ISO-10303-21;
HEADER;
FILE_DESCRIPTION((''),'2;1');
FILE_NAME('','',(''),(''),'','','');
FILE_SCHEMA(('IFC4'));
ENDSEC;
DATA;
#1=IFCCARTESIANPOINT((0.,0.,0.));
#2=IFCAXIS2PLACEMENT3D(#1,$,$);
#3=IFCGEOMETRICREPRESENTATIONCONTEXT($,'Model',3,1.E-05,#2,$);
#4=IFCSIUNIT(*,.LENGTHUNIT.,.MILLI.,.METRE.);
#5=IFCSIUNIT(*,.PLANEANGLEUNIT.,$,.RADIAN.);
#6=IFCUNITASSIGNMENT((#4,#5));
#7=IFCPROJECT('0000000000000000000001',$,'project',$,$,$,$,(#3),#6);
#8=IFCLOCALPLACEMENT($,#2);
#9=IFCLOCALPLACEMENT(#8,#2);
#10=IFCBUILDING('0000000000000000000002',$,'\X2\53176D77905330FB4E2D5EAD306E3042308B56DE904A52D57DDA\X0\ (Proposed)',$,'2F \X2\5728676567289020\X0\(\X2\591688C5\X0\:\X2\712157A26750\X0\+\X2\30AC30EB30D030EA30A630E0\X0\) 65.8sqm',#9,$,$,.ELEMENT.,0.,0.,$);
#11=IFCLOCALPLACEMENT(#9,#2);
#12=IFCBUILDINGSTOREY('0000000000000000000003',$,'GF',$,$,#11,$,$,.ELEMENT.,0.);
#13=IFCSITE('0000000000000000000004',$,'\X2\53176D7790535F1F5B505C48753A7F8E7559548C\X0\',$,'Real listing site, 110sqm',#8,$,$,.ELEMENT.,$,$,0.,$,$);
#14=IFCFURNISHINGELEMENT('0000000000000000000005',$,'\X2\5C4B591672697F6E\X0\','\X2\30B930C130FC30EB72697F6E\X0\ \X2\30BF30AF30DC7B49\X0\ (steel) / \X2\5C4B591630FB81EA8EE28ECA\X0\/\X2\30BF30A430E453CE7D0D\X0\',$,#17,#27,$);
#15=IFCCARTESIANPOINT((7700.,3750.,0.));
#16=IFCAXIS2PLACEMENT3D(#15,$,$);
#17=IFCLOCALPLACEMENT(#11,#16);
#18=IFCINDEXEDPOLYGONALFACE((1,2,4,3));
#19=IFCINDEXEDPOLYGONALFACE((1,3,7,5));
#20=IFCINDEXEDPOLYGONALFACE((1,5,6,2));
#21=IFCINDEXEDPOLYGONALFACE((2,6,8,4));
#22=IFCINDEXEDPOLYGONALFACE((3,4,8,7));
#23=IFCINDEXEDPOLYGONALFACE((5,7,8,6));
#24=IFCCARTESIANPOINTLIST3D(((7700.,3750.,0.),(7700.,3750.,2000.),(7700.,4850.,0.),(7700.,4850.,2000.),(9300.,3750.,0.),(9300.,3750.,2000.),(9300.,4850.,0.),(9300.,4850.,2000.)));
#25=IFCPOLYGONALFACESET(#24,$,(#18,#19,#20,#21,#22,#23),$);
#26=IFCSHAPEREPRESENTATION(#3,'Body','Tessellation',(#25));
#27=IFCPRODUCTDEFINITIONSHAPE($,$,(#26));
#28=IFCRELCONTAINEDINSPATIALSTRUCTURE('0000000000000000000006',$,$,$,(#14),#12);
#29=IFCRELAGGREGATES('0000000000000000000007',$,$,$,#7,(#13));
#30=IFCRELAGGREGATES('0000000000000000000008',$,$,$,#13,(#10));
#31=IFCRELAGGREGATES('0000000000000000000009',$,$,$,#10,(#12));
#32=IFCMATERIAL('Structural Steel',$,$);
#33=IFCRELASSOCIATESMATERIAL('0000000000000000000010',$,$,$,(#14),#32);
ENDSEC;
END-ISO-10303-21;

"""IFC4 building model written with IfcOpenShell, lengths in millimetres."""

from ifc_helpers import new_model, si_unit, frame, frame_2d, origin, place, context, project, spatial, rectangle, extrude, material, element, save


model = new_model("IFC4")

# Units and contexts
model_context = context("Model", 3, precision=1e-05, world=origin())
ifc_project = project(units=[si_unit("LENGTHUNIT", "METRE", prefix="MILLI"), si_unit("PLANEANGLEUNIT", "RADIAN")], contexts=[model_context])

# Site, building, storey
site_placement = place(None, origin())
site = spatial("IfcSite", under=ifc_project, at=site_placement, Name="北海道弟子屈町美留和", ObjectType="Real listing site, 110sqm", CompositionType="ELEMENT", RefElevation=0.0)
building_placement = place(site_placement, origin())
building = spatial("IfcBuilding", under=site, at=building_placement, Name="北海道・中庭のある回遊動線 (Proposed)", ObjectType="2F 在来木造(外装:無垢材+ガルバリウム) 65.8sqm", CompositionType="ELEMENT", ElevationOfRefHeight=0.0, ElevationOfTerrain=0.0)
storey_placement = place(building_placement, origin())
storey = spatial("IfcBuildingStorey", under=building, at=storey_placement, Name="GF", CompositionType="ELEMENT", Elevation=0.0)

# Shared definitions
ifc_material_1 = material(Name="Structural Steel")

# Furnishing element
furnishing_1_placement = place(storey_placement, frame((7700.0, 3750.0, 0.0)))
element("IfcFurnishingElement", 1, at=furnishing_1_placement, inside=storey, material=ifc_material_1, Name="屋外物置", Description="スチール物置 タクボ等 (steel) / 屋外・自転車/タイヤ収納", context=model_context, shape_type="SweptSolid", body=[
    extrude(rectangle(XDim=1600.0, YDim=1100.0, at=frame_2d((800.0, 550.0))), frame((7700.0, 3750.0, 0.0)), (0.0, 0.0, 1.0), 2000.0),
])

save(model, "model.ifc")
